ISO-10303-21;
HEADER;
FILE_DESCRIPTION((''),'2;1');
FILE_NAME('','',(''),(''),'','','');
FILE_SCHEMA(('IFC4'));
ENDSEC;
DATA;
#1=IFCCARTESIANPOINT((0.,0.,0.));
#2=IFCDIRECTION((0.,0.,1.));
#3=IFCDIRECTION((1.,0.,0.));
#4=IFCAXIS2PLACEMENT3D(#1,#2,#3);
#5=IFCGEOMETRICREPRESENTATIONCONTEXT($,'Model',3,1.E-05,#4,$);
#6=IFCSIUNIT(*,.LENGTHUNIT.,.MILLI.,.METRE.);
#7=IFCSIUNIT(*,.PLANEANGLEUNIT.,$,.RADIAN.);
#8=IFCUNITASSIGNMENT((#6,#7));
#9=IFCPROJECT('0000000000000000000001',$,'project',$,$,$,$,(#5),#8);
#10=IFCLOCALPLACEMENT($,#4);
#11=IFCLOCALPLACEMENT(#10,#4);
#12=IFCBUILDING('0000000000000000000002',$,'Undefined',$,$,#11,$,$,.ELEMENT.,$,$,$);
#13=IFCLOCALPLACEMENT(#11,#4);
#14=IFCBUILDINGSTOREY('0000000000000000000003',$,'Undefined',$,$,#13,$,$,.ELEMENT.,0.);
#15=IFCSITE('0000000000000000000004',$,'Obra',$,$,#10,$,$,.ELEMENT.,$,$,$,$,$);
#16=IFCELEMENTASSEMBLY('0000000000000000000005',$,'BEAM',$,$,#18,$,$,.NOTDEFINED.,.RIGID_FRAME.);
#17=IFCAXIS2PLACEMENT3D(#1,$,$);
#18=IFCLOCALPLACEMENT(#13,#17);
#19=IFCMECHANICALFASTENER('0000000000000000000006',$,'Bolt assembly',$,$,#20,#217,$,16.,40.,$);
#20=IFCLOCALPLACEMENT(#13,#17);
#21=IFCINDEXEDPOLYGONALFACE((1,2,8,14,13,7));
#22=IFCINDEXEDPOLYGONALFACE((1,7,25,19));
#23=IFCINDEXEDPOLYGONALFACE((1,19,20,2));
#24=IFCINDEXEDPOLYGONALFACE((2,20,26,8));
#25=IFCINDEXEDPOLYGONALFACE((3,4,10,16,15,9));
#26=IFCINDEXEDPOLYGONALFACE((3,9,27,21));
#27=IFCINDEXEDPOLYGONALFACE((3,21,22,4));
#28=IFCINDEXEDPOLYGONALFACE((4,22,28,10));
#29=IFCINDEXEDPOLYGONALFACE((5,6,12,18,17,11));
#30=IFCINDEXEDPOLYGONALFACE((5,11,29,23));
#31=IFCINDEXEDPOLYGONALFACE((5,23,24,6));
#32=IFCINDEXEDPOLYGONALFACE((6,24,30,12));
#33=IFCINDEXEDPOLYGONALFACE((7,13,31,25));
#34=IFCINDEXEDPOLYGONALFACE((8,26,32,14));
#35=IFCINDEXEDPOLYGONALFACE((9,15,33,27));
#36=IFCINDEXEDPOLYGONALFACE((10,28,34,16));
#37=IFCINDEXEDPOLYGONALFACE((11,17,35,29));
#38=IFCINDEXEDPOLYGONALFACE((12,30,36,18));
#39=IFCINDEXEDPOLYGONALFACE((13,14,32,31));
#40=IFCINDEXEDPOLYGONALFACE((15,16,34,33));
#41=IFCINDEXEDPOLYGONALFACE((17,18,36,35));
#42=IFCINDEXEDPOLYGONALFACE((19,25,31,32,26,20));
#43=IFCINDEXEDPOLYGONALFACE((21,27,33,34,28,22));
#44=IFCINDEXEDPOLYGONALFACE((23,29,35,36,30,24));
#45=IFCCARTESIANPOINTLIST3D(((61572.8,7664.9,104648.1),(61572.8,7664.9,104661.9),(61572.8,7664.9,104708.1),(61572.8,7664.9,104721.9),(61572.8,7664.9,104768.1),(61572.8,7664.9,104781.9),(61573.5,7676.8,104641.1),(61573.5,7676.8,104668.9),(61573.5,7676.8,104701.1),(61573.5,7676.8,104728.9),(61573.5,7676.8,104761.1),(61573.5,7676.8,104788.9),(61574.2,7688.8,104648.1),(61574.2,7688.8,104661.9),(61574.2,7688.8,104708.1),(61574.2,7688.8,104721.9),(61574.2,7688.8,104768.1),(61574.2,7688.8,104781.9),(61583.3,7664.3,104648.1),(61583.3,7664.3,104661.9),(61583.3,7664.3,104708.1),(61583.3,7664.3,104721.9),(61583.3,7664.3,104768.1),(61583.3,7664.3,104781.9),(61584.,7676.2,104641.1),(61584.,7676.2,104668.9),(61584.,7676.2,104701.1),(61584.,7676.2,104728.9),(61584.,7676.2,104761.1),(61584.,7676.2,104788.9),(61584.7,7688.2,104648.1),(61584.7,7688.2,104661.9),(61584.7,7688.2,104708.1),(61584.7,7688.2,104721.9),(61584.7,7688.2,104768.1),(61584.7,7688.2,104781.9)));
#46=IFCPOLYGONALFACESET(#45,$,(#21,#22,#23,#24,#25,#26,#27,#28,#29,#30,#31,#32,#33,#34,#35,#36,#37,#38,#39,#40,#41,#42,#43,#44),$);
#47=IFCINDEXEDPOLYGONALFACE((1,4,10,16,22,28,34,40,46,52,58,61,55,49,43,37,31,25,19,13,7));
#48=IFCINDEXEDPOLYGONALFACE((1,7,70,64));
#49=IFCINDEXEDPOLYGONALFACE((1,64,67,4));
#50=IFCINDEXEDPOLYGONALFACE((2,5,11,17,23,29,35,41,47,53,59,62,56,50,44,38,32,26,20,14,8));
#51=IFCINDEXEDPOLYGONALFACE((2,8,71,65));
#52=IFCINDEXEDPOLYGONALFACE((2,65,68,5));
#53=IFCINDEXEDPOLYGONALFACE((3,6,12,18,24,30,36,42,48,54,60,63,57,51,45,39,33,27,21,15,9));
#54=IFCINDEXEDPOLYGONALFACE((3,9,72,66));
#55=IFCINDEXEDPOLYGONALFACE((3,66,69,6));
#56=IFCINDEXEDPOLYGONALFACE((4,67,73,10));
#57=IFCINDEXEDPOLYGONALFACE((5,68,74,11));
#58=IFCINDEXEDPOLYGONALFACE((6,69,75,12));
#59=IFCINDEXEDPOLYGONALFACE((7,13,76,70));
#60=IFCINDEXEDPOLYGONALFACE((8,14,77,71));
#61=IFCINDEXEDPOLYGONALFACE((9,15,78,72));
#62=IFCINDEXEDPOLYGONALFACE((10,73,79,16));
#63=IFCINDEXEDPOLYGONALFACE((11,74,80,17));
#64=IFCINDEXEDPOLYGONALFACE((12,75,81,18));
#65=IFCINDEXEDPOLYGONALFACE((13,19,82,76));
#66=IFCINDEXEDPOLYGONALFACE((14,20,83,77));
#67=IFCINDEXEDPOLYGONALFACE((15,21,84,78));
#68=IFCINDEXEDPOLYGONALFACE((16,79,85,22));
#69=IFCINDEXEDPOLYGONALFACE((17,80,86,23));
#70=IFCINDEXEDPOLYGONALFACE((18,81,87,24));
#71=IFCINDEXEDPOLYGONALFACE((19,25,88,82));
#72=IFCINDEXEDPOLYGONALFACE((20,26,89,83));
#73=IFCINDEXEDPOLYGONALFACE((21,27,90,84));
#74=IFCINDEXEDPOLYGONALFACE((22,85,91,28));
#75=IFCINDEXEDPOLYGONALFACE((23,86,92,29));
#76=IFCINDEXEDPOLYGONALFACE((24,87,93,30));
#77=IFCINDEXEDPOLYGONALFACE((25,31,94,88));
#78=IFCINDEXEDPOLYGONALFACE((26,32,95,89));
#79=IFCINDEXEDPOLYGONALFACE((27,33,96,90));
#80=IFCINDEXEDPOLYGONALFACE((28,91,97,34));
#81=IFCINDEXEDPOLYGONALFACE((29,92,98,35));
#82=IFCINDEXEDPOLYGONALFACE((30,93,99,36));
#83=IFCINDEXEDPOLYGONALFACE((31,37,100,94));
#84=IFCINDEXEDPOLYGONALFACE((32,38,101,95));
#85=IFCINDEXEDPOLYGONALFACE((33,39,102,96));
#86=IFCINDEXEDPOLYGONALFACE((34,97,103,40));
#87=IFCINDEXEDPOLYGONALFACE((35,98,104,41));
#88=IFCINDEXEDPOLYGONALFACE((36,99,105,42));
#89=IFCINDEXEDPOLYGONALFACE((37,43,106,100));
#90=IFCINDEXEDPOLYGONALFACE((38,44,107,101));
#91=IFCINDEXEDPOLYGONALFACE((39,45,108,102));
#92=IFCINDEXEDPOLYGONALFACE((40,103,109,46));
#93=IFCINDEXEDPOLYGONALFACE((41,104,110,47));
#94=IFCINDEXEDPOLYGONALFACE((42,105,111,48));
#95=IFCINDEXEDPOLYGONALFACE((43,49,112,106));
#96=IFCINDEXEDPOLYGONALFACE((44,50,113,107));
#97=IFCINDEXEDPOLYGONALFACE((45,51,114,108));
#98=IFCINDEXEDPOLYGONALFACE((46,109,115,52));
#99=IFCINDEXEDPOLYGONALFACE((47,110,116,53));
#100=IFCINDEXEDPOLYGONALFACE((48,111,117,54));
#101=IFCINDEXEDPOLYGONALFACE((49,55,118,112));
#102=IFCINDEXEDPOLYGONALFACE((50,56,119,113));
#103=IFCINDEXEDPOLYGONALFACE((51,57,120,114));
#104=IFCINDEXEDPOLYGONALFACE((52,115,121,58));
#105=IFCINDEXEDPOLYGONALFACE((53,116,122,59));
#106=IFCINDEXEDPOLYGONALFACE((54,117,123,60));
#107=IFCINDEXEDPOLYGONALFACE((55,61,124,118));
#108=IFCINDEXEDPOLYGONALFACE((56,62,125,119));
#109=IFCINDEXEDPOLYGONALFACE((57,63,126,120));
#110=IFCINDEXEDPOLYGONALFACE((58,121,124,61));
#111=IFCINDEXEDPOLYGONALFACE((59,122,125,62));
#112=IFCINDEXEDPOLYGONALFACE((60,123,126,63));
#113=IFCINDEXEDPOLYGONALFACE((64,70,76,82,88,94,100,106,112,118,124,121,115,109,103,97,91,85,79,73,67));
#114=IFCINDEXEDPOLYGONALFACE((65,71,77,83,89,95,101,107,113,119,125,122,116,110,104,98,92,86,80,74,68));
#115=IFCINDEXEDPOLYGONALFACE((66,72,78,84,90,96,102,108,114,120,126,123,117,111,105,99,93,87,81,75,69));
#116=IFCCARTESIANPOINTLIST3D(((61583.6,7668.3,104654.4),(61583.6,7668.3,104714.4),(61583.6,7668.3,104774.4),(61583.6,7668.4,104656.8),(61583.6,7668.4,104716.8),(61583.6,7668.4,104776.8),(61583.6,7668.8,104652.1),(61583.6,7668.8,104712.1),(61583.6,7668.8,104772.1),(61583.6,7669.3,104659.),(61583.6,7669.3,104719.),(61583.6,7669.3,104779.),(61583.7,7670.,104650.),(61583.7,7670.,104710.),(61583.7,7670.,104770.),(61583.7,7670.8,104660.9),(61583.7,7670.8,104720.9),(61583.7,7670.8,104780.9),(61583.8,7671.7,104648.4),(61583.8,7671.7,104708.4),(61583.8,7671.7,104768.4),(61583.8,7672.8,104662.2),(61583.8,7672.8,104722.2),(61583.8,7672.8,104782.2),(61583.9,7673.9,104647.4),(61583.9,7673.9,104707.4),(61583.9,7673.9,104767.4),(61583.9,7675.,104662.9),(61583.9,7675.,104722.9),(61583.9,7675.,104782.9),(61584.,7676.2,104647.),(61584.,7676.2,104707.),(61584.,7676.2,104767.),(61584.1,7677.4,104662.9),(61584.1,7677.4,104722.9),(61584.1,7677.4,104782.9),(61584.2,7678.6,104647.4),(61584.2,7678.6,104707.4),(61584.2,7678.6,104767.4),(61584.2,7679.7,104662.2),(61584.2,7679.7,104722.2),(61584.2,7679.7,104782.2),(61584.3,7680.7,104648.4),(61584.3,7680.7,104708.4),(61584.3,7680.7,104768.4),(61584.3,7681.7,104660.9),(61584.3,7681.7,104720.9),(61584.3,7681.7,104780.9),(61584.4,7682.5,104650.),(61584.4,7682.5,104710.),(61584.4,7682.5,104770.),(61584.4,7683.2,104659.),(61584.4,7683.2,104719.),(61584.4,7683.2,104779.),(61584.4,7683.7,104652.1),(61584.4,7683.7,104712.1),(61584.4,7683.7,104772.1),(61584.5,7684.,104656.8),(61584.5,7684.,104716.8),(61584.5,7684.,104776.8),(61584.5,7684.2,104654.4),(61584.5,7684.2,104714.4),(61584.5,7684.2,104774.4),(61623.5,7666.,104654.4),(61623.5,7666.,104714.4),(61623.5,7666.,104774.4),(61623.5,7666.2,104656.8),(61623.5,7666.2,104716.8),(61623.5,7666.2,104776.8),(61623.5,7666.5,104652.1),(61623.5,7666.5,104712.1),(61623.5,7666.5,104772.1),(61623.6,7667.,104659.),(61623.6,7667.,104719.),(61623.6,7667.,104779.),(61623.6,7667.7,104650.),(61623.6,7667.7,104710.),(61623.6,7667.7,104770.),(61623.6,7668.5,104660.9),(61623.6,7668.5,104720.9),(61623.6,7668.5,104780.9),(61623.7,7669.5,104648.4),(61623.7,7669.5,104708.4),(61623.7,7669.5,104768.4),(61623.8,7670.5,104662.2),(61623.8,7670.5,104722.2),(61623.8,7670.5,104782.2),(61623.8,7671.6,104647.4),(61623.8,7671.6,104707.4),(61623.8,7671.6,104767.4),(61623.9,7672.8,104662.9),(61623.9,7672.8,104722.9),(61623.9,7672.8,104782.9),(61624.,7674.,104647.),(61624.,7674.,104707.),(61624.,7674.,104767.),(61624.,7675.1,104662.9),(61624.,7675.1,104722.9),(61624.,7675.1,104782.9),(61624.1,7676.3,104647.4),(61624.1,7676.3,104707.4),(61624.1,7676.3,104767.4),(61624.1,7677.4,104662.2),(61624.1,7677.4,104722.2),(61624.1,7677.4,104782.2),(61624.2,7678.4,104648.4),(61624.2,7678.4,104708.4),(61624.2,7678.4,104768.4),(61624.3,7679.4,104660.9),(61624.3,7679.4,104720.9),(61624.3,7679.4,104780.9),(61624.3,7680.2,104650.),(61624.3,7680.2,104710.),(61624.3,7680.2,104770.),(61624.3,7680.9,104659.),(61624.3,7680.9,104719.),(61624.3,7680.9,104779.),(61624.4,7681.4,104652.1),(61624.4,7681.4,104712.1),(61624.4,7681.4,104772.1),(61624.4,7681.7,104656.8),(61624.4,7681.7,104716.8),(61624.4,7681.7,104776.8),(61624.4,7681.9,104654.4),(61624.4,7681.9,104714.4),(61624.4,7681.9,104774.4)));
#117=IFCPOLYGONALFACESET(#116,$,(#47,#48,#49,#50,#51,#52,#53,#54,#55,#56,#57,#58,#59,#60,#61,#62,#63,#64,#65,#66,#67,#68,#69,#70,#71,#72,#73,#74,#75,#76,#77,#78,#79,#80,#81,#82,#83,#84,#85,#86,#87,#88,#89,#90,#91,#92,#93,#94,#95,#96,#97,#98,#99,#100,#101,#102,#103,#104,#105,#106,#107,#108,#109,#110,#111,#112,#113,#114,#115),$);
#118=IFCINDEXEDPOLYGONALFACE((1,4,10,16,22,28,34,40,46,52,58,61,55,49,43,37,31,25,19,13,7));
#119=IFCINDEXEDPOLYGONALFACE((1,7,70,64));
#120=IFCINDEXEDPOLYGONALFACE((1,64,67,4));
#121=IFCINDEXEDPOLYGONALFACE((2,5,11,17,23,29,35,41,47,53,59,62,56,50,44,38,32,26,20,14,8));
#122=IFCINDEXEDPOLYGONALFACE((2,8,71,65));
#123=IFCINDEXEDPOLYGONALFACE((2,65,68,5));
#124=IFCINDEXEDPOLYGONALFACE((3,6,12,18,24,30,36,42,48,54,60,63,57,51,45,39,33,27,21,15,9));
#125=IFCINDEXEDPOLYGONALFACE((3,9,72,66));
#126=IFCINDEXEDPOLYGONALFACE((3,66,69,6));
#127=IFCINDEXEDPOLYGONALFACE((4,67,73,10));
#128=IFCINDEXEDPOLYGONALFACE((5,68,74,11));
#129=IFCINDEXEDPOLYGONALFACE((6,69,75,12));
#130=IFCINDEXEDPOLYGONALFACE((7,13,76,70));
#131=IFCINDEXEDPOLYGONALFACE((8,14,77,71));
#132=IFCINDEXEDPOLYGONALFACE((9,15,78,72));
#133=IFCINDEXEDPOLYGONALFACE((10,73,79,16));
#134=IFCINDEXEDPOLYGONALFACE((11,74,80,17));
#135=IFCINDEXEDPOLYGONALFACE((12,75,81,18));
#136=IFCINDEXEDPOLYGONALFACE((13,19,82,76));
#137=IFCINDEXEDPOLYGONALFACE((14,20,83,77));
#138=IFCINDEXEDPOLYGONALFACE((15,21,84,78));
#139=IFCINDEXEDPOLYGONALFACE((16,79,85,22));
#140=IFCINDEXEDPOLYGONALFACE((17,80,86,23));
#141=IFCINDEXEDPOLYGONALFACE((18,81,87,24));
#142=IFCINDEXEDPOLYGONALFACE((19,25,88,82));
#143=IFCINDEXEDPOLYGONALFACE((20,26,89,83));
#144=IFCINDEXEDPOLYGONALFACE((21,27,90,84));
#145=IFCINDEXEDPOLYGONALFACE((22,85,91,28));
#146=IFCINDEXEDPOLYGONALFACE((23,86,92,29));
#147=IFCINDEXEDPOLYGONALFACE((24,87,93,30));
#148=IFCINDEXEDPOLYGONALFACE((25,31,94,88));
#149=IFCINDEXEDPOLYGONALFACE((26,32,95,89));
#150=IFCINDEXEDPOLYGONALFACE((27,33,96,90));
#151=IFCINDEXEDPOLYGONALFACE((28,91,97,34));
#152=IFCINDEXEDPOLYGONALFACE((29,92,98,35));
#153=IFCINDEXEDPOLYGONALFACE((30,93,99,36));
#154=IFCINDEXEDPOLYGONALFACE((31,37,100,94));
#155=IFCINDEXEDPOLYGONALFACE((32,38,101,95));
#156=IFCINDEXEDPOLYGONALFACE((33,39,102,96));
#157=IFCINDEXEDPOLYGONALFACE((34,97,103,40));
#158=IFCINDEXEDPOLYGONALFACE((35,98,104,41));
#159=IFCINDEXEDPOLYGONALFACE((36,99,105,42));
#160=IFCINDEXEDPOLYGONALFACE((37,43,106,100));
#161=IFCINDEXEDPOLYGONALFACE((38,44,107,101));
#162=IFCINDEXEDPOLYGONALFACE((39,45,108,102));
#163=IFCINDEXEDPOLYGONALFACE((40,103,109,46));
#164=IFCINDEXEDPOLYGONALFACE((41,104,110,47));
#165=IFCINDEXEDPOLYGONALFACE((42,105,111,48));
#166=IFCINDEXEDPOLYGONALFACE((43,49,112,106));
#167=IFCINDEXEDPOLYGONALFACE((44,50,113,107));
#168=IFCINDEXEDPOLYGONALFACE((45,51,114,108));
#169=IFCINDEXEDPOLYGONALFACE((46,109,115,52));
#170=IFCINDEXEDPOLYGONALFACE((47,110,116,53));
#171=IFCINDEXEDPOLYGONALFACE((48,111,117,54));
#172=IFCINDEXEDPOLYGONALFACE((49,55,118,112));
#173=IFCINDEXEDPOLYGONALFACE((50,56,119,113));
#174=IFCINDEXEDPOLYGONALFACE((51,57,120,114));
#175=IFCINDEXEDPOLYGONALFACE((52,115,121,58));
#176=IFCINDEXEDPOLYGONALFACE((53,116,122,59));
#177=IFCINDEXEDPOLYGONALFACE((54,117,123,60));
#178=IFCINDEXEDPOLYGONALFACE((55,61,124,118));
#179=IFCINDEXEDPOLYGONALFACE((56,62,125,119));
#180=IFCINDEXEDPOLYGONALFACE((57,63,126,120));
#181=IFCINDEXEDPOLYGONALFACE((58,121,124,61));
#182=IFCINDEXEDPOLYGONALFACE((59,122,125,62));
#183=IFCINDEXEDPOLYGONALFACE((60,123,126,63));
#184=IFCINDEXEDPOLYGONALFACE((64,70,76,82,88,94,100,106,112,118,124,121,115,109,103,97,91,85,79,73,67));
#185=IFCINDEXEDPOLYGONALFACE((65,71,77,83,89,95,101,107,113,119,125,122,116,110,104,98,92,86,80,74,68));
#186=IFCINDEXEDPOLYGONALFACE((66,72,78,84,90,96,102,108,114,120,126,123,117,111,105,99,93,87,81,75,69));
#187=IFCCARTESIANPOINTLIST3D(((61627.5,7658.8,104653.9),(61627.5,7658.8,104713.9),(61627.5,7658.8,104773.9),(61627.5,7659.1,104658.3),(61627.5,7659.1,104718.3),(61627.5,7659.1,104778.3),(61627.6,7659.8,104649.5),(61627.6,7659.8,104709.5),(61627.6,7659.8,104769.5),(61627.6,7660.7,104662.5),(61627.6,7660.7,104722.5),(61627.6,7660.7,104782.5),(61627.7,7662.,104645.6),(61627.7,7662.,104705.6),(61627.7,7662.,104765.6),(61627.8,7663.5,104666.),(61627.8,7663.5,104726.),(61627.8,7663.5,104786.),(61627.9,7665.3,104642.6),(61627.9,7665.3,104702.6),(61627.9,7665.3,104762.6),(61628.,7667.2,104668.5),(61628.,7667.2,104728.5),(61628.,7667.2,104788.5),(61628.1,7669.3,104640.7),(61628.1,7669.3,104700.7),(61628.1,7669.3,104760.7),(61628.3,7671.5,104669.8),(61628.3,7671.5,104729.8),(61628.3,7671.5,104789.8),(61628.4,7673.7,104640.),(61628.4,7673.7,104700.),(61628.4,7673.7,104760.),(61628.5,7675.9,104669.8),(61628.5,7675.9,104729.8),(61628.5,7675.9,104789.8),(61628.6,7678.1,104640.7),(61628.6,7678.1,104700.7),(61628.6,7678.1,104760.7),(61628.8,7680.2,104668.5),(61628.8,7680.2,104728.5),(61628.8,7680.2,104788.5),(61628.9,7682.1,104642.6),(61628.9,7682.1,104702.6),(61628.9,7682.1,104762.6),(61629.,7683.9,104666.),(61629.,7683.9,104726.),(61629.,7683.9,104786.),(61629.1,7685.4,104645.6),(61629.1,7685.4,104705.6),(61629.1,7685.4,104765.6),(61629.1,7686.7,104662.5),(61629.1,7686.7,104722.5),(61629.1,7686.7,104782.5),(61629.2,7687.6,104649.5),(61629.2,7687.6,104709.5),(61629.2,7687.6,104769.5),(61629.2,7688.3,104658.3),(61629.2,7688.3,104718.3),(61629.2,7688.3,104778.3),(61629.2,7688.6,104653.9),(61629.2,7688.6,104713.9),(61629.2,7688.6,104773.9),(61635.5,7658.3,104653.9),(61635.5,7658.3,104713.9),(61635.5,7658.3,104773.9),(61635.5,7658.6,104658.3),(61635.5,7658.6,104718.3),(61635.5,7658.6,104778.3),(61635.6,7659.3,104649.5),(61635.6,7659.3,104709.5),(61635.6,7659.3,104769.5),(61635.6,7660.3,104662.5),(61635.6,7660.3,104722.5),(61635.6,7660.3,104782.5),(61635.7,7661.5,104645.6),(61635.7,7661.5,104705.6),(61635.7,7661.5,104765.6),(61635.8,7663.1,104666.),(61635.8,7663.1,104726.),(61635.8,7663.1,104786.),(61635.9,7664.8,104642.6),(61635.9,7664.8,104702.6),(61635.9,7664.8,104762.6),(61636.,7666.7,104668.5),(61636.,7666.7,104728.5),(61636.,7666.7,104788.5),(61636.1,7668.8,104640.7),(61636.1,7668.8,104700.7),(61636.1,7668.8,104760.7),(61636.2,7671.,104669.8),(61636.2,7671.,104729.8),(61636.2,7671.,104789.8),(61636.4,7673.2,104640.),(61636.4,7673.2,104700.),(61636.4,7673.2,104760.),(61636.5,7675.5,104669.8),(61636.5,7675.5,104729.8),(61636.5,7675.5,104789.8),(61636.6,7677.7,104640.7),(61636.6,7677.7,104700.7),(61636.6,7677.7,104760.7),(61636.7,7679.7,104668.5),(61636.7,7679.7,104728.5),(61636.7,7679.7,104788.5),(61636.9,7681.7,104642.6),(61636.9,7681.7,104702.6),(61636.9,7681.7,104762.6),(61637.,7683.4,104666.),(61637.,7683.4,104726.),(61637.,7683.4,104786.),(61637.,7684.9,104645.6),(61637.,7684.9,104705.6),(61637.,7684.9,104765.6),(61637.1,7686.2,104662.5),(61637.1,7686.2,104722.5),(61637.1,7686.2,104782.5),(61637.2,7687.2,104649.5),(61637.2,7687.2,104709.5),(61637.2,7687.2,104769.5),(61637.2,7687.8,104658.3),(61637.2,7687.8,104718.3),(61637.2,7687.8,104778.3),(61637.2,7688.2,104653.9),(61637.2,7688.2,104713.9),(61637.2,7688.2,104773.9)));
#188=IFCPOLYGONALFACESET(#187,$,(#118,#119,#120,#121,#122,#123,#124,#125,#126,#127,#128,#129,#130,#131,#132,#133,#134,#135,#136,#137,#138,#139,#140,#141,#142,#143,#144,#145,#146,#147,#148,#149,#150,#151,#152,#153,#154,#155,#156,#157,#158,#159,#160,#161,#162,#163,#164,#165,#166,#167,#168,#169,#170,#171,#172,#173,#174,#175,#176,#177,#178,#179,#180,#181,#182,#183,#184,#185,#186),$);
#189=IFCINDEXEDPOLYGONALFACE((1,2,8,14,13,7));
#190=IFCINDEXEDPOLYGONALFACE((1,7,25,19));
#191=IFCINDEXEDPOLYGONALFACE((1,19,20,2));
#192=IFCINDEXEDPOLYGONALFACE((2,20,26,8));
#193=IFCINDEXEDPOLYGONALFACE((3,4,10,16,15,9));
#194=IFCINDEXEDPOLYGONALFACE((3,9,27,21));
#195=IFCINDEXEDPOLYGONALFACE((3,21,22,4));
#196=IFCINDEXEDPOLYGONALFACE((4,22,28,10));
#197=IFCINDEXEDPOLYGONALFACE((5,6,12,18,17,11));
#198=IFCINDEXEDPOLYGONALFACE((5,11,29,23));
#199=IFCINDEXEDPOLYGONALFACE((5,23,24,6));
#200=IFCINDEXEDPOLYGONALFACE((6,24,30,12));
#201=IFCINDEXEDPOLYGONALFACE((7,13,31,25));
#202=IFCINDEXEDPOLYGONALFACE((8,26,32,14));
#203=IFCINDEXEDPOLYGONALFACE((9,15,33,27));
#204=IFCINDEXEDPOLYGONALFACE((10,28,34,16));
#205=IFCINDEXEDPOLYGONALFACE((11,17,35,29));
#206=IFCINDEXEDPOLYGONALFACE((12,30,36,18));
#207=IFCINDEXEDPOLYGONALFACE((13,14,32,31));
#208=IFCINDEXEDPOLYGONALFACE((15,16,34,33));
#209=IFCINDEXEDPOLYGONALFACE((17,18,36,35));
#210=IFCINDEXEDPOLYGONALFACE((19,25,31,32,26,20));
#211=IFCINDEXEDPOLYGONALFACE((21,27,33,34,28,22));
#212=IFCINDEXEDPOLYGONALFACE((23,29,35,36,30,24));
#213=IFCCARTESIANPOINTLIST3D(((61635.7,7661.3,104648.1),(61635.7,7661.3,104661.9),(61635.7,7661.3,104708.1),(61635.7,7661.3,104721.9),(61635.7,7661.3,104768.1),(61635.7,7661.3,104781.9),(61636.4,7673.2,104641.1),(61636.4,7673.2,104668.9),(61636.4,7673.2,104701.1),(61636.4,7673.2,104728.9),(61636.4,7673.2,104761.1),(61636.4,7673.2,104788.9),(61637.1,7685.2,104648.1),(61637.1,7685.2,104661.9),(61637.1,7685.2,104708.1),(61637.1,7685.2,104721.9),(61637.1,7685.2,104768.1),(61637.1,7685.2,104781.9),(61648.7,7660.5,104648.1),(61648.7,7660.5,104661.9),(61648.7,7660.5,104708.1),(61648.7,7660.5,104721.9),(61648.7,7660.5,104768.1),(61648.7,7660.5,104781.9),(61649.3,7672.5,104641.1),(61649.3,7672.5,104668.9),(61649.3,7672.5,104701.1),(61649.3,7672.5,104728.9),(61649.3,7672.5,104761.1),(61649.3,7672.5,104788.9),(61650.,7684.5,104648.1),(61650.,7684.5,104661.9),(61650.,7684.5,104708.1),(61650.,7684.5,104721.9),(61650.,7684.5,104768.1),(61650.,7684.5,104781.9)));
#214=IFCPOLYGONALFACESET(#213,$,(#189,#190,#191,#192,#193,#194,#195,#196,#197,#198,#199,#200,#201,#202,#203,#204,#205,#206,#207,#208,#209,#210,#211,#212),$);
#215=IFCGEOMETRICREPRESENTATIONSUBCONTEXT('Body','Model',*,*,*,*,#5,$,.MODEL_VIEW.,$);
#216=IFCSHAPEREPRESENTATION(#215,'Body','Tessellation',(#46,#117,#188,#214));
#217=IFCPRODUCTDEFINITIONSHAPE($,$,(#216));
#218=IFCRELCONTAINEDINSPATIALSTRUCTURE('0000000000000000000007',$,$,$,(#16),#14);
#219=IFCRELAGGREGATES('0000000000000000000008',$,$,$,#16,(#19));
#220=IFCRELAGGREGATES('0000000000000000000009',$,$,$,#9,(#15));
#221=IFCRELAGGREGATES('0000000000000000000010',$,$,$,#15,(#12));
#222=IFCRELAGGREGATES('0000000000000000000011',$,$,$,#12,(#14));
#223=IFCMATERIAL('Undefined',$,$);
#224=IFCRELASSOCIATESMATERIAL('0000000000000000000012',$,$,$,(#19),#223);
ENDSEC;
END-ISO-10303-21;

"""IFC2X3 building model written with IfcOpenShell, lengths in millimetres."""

from ifc_helpers import new_model, si_unit, frame, origin_with_axes, origin_2d_with_axis, place, context, subcontext, project, spatial, polyline, circle, outline, extrude, source, transform, mapped, material, element, aggregate, save


model = new_model("IFC2X3")

# Units and contexts
model_context = context("Model", 3, precision=1e-05, world=origin_with_axes())
body_context = subcontext(model_context, "Body", "Model", "MODEL_VIEW")
ifc_project = project(units=[si_unit("LENGTHUNIT", "METRE", prefix="MILLI"), si_unit("PLANEANGLEUNIT", "RADIAN")], contexts=[model_context])

# Site, building, storey
site_placement = place(None, origin_with_axes())
site = spatial("IfcSite", under=ifc_project, at=site_placement, Name="Obra", CompositionType="ELEMENT")
building_placement = place(site_placement, origin_with_axes())
building = spatial("IfcBuilding", under=site, at=building_placement, Name="Undefined", CompositionType="ELEMENT")
storey_placement = place(building_placement, origin_with_axes())
storey = spatial("IfcBuildingStorey", under=building, at=storey_placement, Name="Undefined", CompositionType="ELEMENT", Elevation=0.0)

# Shared definitions
ifc_material_1 = material(Name="Undefined")

# Shared definitions
shared_shape_1 = source(origin_with_axes(), body_context, "Body", "SweptSolid", [
    extrude(outline(polyline([(13.9, 0.0), (6.9, 12.0), (-6.9, 12.0), (-13.9, 0.0), (-6.9, -12.0), (6.9, -12.0), (13.9, 0.0)])), frame((0.0, -19.7, 0.0), z_axis=(0.0, 1.0, 0.0), x_axis=(1.0, 0.0, 0.0)), (0.0, 0.0, 1.0), 10.6),
    extrude(circle(Radius=8.0, at=origin_2d_with_axis()), frame((0.0, -9.1, 0.0), z_axis=(0.0, 1.0, 0.0), x_axis=(1.0, 0.0, 0.0)), (0.0, 0.0, 1.0), 40.0),
    extrude(circle(Radius=15.0, at=origin_2d_with_axis()), frame((0.0, 35.3, 0.0), z_axis=(0.0, 1.0, 0.0), x_axis=(1.0, 0.0, 0.0)), (0.0, 0.0, 1.0), 8.0),
    extrude(outline(polyline([(13.9, 0.0), (6.9, 12.0), (-6.9, 12.0), (-13.9, 0.0), (-6.9, -12.0), (6.9, -12.0), (13.9, 0.0)])), frame((0.0, 43.3, 0.0), z_axis=(0.0, 1.0, 0.0), x_axis=(1.0, 0.0, 0.0)), (0.0, 0.0, 1.0), 13.0),
])

# Element assembly, mechanical fastener
assembly_1_placement = place(storey_placement, origin_with_axes())
assembly_1 = element("IfcElementAssembly", 1, at=assembly_1_placement, inside=storey, Name="BEAM", AssemblyPlace="NOTDEFINED", PredefinedType="RIGID_FRAME")
mechanical_fastener_1_placement = place(assembly_1_placement, frame((61596.0, 7725.6, 104835.0), z_axis=(-0.05711, -0.998368, 0.0), x_axis=(0.0, 0.0, -1.0)))
mechanical_fastener_1 = element("IfcMechanicalFastener", 2, at=mechanical_fastener_1_placement, material=ifc_material_1, Name="Bolt assembly", NominalDiameter=16.0, NominalLength=40.0, context=body_context, shape_type="MappedRepresentation", body=[
    mapped(shared_shape_1, transform((60.0, 0.0, 50.0))),
    mapped(shared_shape_1, transform((120.0, 0.0, 50.0))),
    mapped(shared_shape_1, transform((180.0, 0.0, 50.0))),
])
aggregate(assembly_1, [mechanical_fastener_1])

save(model, "model.ifc")
